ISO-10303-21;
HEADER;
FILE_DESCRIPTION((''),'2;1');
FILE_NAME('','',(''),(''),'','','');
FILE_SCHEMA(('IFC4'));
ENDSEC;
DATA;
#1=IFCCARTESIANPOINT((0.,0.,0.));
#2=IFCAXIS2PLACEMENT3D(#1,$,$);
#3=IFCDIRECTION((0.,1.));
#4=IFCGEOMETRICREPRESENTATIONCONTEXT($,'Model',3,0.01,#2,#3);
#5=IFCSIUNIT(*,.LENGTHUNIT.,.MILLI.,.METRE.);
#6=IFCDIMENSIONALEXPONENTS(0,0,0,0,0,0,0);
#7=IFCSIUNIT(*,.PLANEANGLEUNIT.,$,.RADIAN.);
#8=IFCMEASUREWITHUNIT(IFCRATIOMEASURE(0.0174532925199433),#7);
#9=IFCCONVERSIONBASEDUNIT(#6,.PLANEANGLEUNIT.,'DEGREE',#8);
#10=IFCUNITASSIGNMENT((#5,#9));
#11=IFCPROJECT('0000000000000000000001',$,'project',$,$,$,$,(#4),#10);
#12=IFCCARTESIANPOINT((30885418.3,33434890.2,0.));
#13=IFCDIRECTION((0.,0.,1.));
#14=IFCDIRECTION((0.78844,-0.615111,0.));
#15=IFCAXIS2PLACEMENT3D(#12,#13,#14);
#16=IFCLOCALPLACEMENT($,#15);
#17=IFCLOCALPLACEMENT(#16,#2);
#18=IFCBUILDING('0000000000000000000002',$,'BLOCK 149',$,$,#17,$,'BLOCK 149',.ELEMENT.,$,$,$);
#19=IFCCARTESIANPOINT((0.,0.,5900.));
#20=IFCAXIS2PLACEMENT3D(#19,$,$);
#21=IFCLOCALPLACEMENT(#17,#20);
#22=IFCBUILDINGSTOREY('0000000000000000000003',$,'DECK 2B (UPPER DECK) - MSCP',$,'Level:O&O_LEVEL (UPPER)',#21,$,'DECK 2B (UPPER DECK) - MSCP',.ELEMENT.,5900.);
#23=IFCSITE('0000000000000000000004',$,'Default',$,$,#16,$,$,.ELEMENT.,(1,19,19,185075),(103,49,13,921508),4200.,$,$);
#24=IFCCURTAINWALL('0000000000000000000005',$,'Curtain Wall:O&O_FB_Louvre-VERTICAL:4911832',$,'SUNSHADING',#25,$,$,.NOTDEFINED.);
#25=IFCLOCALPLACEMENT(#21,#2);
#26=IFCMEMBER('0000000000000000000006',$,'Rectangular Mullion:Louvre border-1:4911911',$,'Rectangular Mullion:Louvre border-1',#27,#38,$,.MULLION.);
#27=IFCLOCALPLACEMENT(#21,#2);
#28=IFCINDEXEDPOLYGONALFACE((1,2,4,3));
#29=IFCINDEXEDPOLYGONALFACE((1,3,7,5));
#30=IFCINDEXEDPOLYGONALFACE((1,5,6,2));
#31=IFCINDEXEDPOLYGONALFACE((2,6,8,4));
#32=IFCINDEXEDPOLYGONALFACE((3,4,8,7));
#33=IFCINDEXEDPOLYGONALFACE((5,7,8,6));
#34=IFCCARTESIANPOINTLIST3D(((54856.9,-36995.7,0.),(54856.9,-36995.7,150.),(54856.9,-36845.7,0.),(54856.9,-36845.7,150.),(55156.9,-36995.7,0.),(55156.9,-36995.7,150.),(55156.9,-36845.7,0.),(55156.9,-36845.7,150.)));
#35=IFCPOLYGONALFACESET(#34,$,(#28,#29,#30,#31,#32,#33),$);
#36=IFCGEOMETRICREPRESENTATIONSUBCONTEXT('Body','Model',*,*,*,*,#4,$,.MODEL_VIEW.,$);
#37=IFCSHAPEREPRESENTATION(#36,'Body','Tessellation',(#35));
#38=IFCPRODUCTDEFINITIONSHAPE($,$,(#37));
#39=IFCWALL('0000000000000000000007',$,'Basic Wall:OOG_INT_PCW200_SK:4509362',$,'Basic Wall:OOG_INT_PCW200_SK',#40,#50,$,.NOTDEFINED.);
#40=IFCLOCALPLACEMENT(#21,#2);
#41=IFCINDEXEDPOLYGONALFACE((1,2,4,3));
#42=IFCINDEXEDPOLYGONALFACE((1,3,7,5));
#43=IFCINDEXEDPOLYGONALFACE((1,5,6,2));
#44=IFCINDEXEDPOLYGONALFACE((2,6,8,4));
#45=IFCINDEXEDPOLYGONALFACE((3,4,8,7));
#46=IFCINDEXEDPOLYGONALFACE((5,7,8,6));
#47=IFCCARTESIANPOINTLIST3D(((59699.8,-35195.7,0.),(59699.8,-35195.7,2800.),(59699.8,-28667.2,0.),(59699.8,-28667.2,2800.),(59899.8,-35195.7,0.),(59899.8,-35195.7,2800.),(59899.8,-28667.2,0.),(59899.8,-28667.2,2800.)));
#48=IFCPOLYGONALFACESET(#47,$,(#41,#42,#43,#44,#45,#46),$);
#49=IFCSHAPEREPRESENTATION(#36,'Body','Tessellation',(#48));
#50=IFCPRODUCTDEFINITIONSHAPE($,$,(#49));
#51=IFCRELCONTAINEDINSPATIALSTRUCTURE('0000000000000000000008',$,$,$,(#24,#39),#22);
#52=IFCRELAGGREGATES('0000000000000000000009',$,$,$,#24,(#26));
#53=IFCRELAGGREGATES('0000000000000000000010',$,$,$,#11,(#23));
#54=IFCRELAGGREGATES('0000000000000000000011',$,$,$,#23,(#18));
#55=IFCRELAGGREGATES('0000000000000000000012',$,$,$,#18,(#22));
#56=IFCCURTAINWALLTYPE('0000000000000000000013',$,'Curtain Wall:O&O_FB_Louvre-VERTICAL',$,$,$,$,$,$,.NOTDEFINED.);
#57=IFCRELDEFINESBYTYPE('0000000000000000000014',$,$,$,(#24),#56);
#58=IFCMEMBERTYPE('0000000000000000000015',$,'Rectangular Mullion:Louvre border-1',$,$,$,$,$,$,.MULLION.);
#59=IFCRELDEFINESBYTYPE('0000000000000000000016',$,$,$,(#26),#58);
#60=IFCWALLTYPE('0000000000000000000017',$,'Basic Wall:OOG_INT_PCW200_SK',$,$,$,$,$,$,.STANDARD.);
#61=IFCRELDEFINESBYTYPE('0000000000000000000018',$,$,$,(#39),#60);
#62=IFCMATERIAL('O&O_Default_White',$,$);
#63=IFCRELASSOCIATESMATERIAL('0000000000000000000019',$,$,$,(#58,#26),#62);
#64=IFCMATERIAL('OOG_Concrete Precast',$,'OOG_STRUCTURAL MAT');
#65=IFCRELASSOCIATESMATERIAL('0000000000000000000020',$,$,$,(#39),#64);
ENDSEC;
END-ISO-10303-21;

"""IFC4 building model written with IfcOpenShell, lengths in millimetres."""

from ifc_helpers import new_model, entity, si_unit, converted_unit, direction, frame, origin, place, context, subcontext, project, spatial, indexed_curve, outline, extrude, source, transform, mapped, material, type_object, type_shapes, element, aggregate, save


model = new_model("IFC4")

# Units and contexts
model_context = context("Model", 3, precision=0.01, world=origin(), true_north=direction((0.0, 1.0)))
body_context = subcontext(model_context, "Body", "Model", "MODEL_VIEW")
ifc_project = project(units=[si_unit("LENGTHUNIT", "METRE", prefix="MILLI"), converted_unit("PLANEANGLEUNIT", "DEGREE", entity("IfcRatioMeasure", 0.0174532925199433), si_unit("PLANEANGLEUNIT", "RADIAN"), dimensions=[0, 0, 0, 0, 0, 0, 0])], contexts=[model_context])

# Site, building, storey
site_placement = place(None, frame((30885418.3, 33434890.2, 0.0), z_axis=(0.0, 0.0, 1.0), x_axis=(0.78844, -0.615111, 0.0)))
site = spatial("IfcSite", under=ifc_project, at=site_placement, Name="Default", CompositionType="ELEMENT", RefLatitude=(1, 19, 19, 185075), RefLongitude=(103, 49, 13, 921508), RefElevation=4200.0)
building_placement = place(site_placement, origin())
building = spatial("IfcBuilding", under=site, at=building_placement, Name="BLOCK 149", LongName="BLOCK 149", CompositionType="ELEMENT")
storey_placement = place(building_placement, frame((0.0, 0.0, 5900.0)))
storey = spatial("IfcBuildingStorey", under=building, at=storey_placement, Name="DECK 2B (UPPER DECK) - MSCP", ObjectType="Level:O&O_LEVEL (UPPER)", LongName="DECK 2B (UPPER DECK) - MSCP", CompositionType="ELEMENT", Elevation=5900.0)

# Curtain wall, member
curtain_wall_type = type_object("IfcCurtainWallType", Name="Curtain Wall:O&O_FB_Louvre-VERTICAL", PredefinedType="NOTDEFINED")
curtain_wall_placement = place(storey_placement, frame((0.0, 0.0, -5900.0)))
curtain_wall = element("IfcCurtainWall", 1, at=curtain_wall_placement, inside=storey, type_object=curtain_wall_type, Name="Curtain Wall:O&O_FB_Louvre-VERTICAL:4911832", ObjectType="SUNSHADING", PredefinedType="NOTDEFINED")
ifc_material_1 = material(Name="O&O_Default_White")
placement = place(building_placement, origin())
member_type_1 = type_object("IfcMemberType", Name="Rectangular Mullion:Louvre border-1", PredefinedType="MULLION", material=ifc_material_1)
shared_shape_1 = source(origin(), body_context, "Body", "SweptSolid", [
    extrude(outline(indexed_curve([(-75.0, -75.0), (75.0, -75.0), (75.0, 75.0), (-75.0, 75.0), (-75.0, -75.0)], self_intersect=False)), frame((-75.0, 0.0, -300.0), z_axis=(0.0, 0.0, 1.0), x_axis=(0.0, -1.0, 0.0)), (0.0, 0.0, 1.0), 300.0),
])
type_shapes(member_type_1, [shared_shape_1])
member_1_placement = place(placement, frame((55156.9, -36920.7, 5900.0), z_axis=(1.0, 0.0, 0.0), x_axis=(0.0, 0.0, -1.0)))
member_1 = element("IfcMember", 2, at=member_1_placement, type_object=member_type_1, material=ifc_material_1, Name="Rectangular Mullion:Louvre border-1:4911911", ObjectType="Rectangular Mullion:Louvre border-1", PredefinedType="MULLION", context=body_context, shape_type="MappedRepresentation", body=[
    mapped(shared_shape_1, transform((0.0, 0.0, 0.0), scale=1.0)),
])
aggregate(curtain_wall, [member_1])

# Wall
ifc_material_2 = material(Name="OOG_Concrete Precast", Category="OOG_STRUCTURAL MAT")
wall_type = type_object("IfcWallType", Name="Basic Wall:OOG_INT_PCW200_SK", PredefinedType="STANDARD")
wall_placement = place(storey_placement, frame((59799.8, -35195.7, 0.0), z_axis=(0.0, 0.0, 1.0), x_axis=(0.0, 1.0, 0.0)))
element("IfcWall", 3, at=wall_placement, inside=storey, type_object=wall_type, material=ifc_material_2, Name="Basic Wall:OOG_INT_PCW200_SK:4509362", ObjectType="Basic Wall:OOG_INT_PCW200_SK", PredefinedType="NOTDEFINED", context=body_context, shape_type="SweptSolid", body=[
    extrude(outline(indexed_curve([(6528.5, 100.0), (0.0, 100.0), (0.0, -100.0), (6528.5, -100.0), (6528.5, 100.0)], self_intersect=False)), origin(), (0.0, 0.0, 1.0), 2800.0),
])

save(model, "model.ifc")
